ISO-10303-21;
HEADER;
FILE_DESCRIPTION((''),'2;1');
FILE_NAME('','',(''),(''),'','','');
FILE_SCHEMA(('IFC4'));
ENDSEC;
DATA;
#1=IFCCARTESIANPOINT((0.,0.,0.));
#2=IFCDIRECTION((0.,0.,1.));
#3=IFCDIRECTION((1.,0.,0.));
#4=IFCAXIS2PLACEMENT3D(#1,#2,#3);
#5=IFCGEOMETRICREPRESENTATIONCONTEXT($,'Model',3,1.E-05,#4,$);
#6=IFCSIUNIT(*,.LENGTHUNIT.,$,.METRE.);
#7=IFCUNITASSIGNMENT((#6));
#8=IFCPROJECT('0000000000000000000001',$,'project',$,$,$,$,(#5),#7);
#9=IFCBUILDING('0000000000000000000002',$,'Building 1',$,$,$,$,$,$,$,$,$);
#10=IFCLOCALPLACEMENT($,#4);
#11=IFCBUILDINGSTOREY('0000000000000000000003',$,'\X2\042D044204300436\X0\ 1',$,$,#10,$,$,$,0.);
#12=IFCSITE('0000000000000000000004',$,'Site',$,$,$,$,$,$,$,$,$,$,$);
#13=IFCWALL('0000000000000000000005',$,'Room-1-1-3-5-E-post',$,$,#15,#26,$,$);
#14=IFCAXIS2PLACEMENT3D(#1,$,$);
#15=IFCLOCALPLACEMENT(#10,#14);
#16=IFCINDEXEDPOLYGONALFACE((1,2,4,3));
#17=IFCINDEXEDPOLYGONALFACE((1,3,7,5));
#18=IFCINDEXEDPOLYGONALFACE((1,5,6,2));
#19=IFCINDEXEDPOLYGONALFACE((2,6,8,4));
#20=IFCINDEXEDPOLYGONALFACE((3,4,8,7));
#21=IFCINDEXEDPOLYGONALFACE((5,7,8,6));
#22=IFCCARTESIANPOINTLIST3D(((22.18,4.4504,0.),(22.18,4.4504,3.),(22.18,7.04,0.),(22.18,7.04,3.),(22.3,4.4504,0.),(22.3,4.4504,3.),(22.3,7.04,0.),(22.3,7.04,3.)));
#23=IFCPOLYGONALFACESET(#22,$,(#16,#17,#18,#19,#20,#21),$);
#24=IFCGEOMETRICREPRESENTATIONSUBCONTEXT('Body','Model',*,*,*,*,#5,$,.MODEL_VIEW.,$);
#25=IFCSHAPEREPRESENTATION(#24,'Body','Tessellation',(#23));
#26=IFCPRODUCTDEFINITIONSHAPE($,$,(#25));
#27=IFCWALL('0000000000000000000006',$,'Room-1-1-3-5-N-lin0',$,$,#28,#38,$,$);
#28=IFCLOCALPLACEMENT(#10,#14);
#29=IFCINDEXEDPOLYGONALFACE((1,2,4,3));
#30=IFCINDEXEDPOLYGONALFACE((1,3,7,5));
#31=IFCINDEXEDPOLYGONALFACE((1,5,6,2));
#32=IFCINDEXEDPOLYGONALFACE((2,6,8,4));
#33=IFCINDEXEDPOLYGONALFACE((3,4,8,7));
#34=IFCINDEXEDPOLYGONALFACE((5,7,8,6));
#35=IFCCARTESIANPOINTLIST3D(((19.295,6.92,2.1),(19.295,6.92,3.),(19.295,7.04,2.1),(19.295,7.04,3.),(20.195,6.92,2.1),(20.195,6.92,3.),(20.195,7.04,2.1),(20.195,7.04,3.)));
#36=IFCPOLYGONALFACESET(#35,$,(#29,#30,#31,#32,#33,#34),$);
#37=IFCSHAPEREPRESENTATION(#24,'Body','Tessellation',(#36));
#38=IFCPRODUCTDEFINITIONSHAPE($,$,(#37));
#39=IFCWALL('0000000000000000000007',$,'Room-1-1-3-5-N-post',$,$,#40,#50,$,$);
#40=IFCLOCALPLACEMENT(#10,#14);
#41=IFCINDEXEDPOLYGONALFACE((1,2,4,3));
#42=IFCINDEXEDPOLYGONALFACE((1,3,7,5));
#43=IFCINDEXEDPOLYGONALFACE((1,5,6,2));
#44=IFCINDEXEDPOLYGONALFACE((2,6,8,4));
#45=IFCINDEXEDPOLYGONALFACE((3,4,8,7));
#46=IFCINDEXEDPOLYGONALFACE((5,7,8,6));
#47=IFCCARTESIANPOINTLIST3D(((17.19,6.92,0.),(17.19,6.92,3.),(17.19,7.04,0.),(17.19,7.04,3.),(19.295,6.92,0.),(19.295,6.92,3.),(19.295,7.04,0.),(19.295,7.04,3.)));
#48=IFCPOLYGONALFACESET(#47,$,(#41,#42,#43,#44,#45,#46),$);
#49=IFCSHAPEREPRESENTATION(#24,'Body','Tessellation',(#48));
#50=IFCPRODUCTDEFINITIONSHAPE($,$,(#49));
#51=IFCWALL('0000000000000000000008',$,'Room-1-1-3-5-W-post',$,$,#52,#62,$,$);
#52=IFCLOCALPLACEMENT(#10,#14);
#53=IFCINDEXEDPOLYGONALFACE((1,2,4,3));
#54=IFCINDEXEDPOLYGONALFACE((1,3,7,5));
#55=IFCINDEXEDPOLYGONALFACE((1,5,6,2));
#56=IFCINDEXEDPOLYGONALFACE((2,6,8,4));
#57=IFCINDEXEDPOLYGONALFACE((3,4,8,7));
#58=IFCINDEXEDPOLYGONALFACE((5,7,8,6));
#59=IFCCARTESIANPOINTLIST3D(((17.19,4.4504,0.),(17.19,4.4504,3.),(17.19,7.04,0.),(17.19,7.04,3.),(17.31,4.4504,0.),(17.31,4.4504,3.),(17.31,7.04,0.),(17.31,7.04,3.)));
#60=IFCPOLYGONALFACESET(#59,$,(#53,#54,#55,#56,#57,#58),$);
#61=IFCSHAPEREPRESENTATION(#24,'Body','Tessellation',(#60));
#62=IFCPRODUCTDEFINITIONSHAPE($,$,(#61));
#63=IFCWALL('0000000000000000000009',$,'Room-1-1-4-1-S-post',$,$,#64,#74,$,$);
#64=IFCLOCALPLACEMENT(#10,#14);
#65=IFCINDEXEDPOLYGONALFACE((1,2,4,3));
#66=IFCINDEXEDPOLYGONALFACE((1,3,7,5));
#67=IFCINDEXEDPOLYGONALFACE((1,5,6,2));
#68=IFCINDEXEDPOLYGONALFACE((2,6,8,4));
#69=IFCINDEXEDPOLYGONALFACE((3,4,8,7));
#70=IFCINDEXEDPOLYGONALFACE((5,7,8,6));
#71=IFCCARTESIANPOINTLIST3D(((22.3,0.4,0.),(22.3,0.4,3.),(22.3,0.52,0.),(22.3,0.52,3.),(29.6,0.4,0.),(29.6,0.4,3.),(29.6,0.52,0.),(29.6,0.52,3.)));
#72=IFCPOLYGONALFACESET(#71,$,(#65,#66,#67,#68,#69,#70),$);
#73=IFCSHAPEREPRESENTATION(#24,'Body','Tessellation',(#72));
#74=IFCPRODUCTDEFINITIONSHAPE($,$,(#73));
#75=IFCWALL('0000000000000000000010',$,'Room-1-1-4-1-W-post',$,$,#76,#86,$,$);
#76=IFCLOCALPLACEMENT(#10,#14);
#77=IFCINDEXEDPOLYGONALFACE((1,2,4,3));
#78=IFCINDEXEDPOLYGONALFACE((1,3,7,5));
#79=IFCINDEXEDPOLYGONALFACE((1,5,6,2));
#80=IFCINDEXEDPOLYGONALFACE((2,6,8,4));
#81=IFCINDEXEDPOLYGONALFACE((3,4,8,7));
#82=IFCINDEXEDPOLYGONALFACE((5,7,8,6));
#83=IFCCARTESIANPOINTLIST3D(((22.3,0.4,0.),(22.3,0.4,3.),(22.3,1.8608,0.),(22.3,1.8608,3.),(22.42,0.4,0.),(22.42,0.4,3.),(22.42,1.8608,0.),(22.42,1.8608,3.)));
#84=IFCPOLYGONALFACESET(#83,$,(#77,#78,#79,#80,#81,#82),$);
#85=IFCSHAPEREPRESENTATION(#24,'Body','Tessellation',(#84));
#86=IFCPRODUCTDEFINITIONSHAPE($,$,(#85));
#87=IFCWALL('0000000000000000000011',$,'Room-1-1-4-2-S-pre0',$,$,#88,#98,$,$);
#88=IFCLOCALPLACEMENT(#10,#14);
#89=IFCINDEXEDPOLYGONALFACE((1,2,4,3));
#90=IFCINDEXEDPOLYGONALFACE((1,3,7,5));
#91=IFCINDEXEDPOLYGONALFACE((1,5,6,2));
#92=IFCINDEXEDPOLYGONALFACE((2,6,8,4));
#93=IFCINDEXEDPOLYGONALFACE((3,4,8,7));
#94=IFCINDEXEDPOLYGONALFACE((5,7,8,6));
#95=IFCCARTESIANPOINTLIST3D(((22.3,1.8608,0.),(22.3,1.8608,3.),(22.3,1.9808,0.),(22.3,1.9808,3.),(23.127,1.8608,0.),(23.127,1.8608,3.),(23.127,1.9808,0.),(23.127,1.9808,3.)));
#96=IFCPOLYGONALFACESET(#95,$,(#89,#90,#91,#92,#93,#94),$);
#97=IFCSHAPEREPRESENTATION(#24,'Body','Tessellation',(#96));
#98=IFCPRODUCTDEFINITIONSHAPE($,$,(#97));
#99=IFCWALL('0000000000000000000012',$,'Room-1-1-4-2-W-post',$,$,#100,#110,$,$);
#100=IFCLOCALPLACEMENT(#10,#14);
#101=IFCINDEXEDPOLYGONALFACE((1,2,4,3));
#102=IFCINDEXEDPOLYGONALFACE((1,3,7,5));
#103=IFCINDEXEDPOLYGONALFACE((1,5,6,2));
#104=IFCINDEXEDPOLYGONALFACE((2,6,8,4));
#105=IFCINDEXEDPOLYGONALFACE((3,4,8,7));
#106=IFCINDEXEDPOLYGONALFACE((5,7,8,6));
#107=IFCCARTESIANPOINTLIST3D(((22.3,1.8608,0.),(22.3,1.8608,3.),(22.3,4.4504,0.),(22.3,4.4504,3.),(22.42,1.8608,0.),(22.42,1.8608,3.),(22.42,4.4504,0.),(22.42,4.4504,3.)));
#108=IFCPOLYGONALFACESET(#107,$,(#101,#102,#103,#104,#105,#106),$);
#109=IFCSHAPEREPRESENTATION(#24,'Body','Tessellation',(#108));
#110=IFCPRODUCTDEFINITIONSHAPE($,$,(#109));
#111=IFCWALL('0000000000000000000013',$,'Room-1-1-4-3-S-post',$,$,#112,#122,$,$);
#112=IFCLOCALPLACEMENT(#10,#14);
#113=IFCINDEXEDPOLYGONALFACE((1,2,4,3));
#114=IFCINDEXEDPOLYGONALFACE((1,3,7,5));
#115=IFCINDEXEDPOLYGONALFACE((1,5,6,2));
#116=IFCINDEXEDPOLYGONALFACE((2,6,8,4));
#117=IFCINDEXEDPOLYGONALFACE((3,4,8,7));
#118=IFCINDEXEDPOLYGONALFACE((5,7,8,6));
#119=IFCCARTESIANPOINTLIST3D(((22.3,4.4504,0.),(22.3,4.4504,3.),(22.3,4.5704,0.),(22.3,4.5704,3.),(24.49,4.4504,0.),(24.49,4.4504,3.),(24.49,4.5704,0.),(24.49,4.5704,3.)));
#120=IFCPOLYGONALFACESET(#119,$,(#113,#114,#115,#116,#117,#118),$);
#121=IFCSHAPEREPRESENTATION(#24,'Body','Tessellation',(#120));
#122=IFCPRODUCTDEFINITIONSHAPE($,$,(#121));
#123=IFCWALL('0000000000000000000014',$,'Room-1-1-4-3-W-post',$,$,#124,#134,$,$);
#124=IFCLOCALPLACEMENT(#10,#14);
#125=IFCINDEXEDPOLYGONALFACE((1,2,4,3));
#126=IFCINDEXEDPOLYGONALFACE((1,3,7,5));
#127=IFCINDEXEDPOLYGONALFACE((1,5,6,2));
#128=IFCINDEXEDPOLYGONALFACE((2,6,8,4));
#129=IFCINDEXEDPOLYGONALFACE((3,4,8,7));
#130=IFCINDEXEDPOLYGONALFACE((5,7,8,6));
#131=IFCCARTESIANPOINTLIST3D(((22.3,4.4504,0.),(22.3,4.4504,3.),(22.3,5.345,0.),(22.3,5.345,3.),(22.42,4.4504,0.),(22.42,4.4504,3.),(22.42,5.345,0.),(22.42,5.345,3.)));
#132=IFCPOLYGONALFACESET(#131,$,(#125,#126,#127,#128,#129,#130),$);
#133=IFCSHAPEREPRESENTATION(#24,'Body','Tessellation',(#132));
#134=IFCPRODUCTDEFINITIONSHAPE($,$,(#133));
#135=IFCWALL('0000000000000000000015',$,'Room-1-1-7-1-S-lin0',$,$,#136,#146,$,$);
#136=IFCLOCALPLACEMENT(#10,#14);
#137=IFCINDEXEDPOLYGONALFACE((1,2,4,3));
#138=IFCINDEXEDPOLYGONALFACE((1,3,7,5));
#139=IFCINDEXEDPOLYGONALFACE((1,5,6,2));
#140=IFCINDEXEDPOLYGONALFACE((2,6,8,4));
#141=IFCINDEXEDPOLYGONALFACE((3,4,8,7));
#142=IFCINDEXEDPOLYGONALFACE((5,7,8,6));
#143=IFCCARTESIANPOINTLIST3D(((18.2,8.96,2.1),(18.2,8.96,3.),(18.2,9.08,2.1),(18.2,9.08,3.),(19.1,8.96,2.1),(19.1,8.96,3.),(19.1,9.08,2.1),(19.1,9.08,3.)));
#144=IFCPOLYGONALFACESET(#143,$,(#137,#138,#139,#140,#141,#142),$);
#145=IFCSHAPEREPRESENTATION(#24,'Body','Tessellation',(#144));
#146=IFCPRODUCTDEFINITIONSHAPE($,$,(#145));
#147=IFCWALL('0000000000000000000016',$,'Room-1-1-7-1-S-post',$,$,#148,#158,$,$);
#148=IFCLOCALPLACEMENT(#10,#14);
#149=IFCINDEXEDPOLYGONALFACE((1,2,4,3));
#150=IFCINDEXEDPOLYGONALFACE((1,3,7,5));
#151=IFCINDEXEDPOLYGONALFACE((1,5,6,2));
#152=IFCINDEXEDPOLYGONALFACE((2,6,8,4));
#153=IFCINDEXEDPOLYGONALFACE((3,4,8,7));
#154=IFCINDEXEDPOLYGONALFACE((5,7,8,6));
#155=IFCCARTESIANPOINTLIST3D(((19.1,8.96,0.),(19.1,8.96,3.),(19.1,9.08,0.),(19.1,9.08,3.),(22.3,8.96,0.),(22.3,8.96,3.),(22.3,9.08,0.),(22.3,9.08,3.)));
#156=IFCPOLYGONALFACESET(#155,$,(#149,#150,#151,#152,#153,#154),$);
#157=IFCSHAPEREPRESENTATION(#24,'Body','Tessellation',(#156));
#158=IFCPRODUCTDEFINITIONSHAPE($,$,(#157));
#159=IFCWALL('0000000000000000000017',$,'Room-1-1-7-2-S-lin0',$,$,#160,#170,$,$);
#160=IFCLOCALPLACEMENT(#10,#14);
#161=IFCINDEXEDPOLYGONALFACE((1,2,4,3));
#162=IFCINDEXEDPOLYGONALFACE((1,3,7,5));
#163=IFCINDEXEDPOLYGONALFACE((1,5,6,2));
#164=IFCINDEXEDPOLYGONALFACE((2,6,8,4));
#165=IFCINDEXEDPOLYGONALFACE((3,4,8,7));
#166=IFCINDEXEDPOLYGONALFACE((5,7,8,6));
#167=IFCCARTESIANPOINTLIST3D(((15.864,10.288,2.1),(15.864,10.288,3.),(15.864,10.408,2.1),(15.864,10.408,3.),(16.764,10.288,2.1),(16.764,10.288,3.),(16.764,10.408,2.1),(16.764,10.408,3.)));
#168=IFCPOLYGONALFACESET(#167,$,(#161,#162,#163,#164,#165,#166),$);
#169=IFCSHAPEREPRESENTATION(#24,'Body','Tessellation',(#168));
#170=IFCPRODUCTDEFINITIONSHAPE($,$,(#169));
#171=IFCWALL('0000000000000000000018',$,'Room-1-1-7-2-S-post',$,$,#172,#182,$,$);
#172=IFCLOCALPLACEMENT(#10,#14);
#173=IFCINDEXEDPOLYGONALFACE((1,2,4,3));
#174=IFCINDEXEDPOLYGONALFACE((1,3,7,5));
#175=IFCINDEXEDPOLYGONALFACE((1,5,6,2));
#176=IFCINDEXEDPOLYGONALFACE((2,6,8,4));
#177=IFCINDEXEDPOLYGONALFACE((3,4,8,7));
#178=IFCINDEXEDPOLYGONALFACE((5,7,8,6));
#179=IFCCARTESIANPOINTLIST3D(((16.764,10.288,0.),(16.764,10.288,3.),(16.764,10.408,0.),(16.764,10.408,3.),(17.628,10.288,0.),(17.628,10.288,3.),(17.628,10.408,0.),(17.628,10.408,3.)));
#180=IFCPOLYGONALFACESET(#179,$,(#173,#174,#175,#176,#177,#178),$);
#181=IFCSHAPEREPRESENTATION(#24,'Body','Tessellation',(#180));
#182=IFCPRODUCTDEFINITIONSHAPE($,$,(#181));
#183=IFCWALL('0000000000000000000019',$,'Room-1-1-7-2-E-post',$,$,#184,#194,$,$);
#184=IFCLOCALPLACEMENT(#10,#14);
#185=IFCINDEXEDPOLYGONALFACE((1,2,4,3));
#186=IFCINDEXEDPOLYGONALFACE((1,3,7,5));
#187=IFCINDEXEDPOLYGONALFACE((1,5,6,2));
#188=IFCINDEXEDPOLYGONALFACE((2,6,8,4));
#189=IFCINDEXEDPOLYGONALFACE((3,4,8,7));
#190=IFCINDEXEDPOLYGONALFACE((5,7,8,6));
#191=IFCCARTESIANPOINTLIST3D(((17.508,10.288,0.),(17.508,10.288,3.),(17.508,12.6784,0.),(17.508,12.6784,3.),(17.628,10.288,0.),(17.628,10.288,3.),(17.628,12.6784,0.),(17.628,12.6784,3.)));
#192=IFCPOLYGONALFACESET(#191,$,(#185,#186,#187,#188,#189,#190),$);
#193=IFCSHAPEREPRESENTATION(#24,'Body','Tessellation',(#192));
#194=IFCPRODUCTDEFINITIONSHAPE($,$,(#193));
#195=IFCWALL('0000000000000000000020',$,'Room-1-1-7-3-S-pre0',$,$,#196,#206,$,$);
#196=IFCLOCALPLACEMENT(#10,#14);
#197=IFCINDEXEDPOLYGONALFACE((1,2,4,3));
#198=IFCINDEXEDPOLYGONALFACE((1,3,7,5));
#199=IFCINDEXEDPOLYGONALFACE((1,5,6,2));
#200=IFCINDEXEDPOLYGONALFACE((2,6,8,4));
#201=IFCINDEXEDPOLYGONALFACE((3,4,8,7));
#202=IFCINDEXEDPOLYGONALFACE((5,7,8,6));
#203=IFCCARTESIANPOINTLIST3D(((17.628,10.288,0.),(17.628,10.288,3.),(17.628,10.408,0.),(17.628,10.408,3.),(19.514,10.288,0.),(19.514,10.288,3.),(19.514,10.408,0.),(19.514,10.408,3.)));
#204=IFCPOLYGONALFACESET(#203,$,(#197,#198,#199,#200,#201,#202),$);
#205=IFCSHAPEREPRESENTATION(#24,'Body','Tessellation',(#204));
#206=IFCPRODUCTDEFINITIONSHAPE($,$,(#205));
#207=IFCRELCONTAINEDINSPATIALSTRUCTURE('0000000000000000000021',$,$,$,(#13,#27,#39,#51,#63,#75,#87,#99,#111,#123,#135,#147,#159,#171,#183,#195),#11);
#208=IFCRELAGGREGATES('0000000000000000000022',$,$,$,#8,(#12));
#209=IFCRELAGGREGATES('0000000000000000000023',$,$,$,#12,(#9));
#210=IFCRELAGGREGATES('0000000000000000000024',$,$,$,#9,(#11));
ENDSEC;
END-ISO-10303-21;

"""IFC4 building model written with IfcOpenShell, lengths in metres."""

from ifc_helpers import new_model, si_unit, frame, origin_with_axes, place, context, subcontext, project, spatial, indexed_curve, outline, extrude, element, save


model = new_model("IFC4")

# Units and contexts
model_context = context("Model", 3, precision=1e-05, world=origin_with_axes())
body_context = subcontext(model_context, "Body", "Model", "MODEL_VIEW")
ifc_project = project(units=[si_unit("LENGTHUNIT", "METRE")], contexts=[model_context])

# Site, building, storey
site = spatial("IfcSite", under=ifc_project, Name="Site")
building = spatial("IfcBuilding", under=site, Name="Building 1")
storey_placement = place(None, origin_with_axes())
storey = spatial("IfcBuildingStorey", under=building, at=storey_placement, Name="Этаж 1", Elevation=0.0)

# Walls
wall_1_placement = place(storey_placement, frame((22.3, 4.4504, 0.0), z_axis=(0.0, 0.0, 1.0), x_axis=(0.0, 1.0, 0.0)))
element("IfcWall", 1, at=wall_1_placement, inside=storey, Name="Room-1-1-3-5-E-post", context=body_context, shape_type="SweptSolid", body=[
    extrude(outline(indexed_curve([(0.0, 0.0), (0.0, 0.12), (2.5896, 0.12), (2.5896, 0.0), (0.0, 0.0)], self_intersect=False)), origin_with_axes(), (0.0, 0.0, 1.0), 3.0),
])
wall_2_placement = place(storey_placement, frame((20.195, 7.04, 2.1), z_axis=(0.0, 0.0, 1.0), x_axis=(-1.0, 0.0, 0.0)))
element("IfcWall", 2, at=wall_2_placement, inside=storey, Name="Room-1-1-3-5-N-lin0", context=body_context, shape_type="SweptSolid", body=[
    extrude(outline(indexed_curve([(0.0, 0.0), (0.0, 0.12), (0.9, 0.12), (0.9, 0.0), (0.0, 0.0)], self_intersect=False)), origin_with_axes(), (0.0, 0.0, 1.0), 0.9),
])
wall_3_placement = place(storey_placement, frame((19.295, 7.04, 0.0), z_axis=(0.0, 0.0, 1.0), x_axis=(-1.0, 0.0, 0.0)))
element("IfcWall", 3, at=wall_3_placement, inside=storey, Name="Room-1-1-3-5-N-post", context=body_context, shape_type="SweptSolid", body=[
    extrude(outline(indexed_curve([(0.0, 0.0), (0.0, 0.12), (2.105, 0.12), (2.105, 0.0), (0.0, 0.0)], self_intersect=False)), origin_with_axes(), (0.0, 0.0, 1.0), 3.0),
])
wall_4_placement = place(storey_placement, frame((17.19, 7.04, 0.0), z_axis=(0.0, 0.0, 1.0), x_axis=(0.0, -1.0, 0.0)))
element("IfcWall", 4, at=wall_4_placement, inside=storey, Name="Room-1-1-3-5-W-post", context=body_context, shape_type="SweptSolid", body=[
    extrude(outline(indexed_curve([(0.0, 0.0), (0.0, 0.12), (2.5896, 0.12), (2.5896, 0.0), (0.0, 0.0)], self_intersect=False)), origin_with_axes(), (0.0, 0.0, 1.0), 3.0),
])
wall_5_placement = place(storey_placement, frame((22.3, 0.4, 0.0), z_axis=(0.0, 0.0, 1.0), x_axis=(1.0, 0.0, 0.0)))
element("IfcWall", 5, at=wall_5_placement, inside=storey, Name="Room-1-1-4-1-S-post", context=body_context, shape_type="SweptSolid", body=[
    extrude(outline(indexed_curve([(0.0, 0.0), (0.0, 0.12), (7.3, 0.12), (7.3, 0.0), (0.0, 0.0)], self_intersect=False)), origin_with_axes(), (0.0, 0.0, 1.0), 3.0),
])
wall_6_placement = place(storey_placement, frame((22.3, 1.8608, 0.0), z_axis=(0.0, 0.0, 1.0), x_axis=(0.0, -1.0, 0.0)))
element("IfcWall", 6, at=wall_6_placement, inside=storey, Name="Room-1-1-4-1-W-post", context=body_context, shape_type="SweptSolid", body=[
    extrude(outline(indexed_curve([(0.0, 0.0), (0.0, 0.12), (1.4608, 0.12), (1.4608, 0.0), (0.0, 0.0)], self_intersect=False)), origin_with_axes(), (0.0, 0.0, 1.0), 3.0),
])
wall_7_placement = place(storey_placement, frame((22.3, 1.8608, 0.0), z_axis=(0.0, 0.0, 1.0), x_axis=(1.0, 0.0, 0.0)))
element("IfcWall", 7, at=wall_7_placement, inside=storey, Name="Room-1-1-4-2-S-pre0", context=body_context, shape_type="SweptSolid", body=[
    extrude(outline(indexed_curve([(0.0, 0.0), (0.0, 0.12), (0.827, 0.12), (0.827, 0.0), (0.0, 0.0)], self_intersect=False)), origin_with_axes(), (0.0, 0.0, 1.0), 3.0),
])
wall_8_placement = place(storey_placement, frame((22.3, 4.4504, 0.0), z_axis=(0.0, 0.0, 1.0), x_axis=(0.0, -1.0, 0.0)))
element("IfcWall", 8, at=wall_8_placement, inside=storey, Name="Room-1-1-4-2-W-post", context=body_context, shape_type="SweptSolid", body=[
    extrude(outline(indexed_curve([(0.0, 0.0), (0.0, 0.12), (2.5896, 0.12), (2.5896, 0.0), (0.0, 0.0)], self_intersect=False)), origin_with_axes(), (0.0, 0.0, 1.0), 3.0),
])
wall_9_placement = place(storey_placement, frame((22.3, 4.4504, 0.0), z_axis=(0.0, 0.0, 1.0), x_axis=(1.0, 0.0, 0.0)))
element("IfcWall", 9, at=wall_9_placement, inside=storey, Name="Room-1-1-4-3-S-post", context=body_context, shape_type="SweptSolid", body=[
    extrude(outline(indexed_curve([(0.0, 0.0), (0.0, 0.12), (2.19, 0.12), (2.19, 0.0), (0.0, 0.0)], self_intersect=False)), origin_with_axes(), (0.0, 0.0, 1.0), 3.0),
])
wall_10_placement = place(storey_placement, frame((22.3, 5.345, 0.0), z_axis=(0.0, 0.0, 1.0), x_axis=(0.0, -1.0, 0.0)))
element("IfcWall", 10, at=wall_10_placement, inside=storey, Name="Room-1-1-4-3-W-post", context=body_context, shape_type="SweptSolid", body=[
    extrude(outline(indexed_curve([(0.0, 0.0), (0.0, 0.12), (0.8946, 0.12), (0.8946, 0.0), (0.0, 0.0)], self_intersect=False)), origin_with_axes(), (0.0, 0.0, 1.0), 3.0),
])
wall_11_placement = place(storey_placement, frame((18.2, 8.96, 2.1), z_axis=(0.0, 0.0, 1.0), x_axis=(1.0, 0.0, 0.0)))
element("IfcWall", 11, at=wall_11_placement, inside=storey, Name="Room-1-1-7-1-S-lin0", context=body_context, shape_type="SweptSolid", body=[
    extrude(outline(indexed_curve([(0.0, 0.0), (0.0, 0.12), (0.9, 0.12), (0.9, 0.0), (0.0, 0.0)], self_intersect=False)), origin_with_axes(), (0.0, 0.0, 1.0), 0.9),
])
wall_12_placement = place(storey_placement, frame((19.1, 8.96, 0.0), z_axis=(0.0, 0.0, 1.0), x_axis=(1.0, 0.0, 0.0)))
element("IfcWall", 12, at=wall_12_placement, inside=storey, Name="Room-1-1-7-1-S-post", context=body_context, shape_type="SweptSolid", body=[
    extrude(outline(indexed_curve([(0.0, 0.0), (0.0, 0.12), (3.2, 0.12), (3.2, 0.0), (0.0, 0.0)], self_intersect=False)), origin_with_axes(), (0.0, 0.0, 1.0), 3.0),
])
wall_13_placement = place(storey_placement, frame((15.864, 10.288, 2.1), z_axis=(0.0, 0.0, 1.0), x_axis=(1.0, 0.0, 0.0)))
element("IfcWall", 13, at=wall_13_placement, inside=storey, Name="Room-1-1-7-2-S-lin0", context=body_context, shape_type="SweptSolid", body=[
    extrude(outline(indexed_curve([(0.0, 0.0), (0.0, 0.12), (0.9, 0.12), (0.9, 0.0), (0.0, 0.0)], self_intersect=False)), origin_with_axes(), (0.0, 0.0, 1.0), 0.9),
])
wall_14_placement = place(storey_placement, frame((16.764, 10.288, 0.0), z_axis=(0.0, 0.0, 1.0), x_axis=(1.0, 0.0, 0.0)))
element("IfcWall", 14, at=wall_14_placement, inside=storey, Name="Room-1-1-7-2-S-post", context=body_context, shape_type="SweptSolid", body=[
    extrude(outline(indexed_curve([(0.0, 0.0), (0.0, 0.12), (0.864, 0.12), (0.864, 0.0), (0.0, 0.0)], self_intersect=False)), origin_with_axes(), (0.0, 0.0, 1.0), 3.0),
])
wall_15_placement = place(storey_placement, frame((17.628, 10.288, 0.0), z_axis=(0.0, 0.0, 1.0), x_axis=(0.0, 1.0, 0.0)))
element("IfcWall", 15, at=wall_15_placement, inside=storey, Name="Room-1-1-7-2-E-post", context=body_context, shape_type="SweptSolid", body=[
    extrude(outline(indexed_curve([(0.0, 0.0), (0.0, 0.12), (2.3904, 0.12), (2.3904, 0.0), (0.0, 0.0)], self_intersect=False)), origin_with_axes(), (0.0, 0.0, 1.0), 3.0),
])
wall_16_placement = place(storey_placement, frame((17.628, 10.288, 0.0), z_axis=(0.0, 0.0, 1.0), x_axis=(1.0, 0.0, 0.0)))
element("IfcWall", 16, at=wall_16_placement, inside=storey, Name="Room-1-1-7-3-S-pre0", context=body_context, shape_type="SweptSolid", body=[
    extrude(outline(indexed_curve([(0.0, 0.0), (0.0, 0.12), (1.886, 0.12), (1.886, 0.0), (0.0, 0.0)], self_intersect=False)), origin_with_axes(), (0.0, 0.0, 1.0), 3.0),
])

save(model, "model.ifc")
